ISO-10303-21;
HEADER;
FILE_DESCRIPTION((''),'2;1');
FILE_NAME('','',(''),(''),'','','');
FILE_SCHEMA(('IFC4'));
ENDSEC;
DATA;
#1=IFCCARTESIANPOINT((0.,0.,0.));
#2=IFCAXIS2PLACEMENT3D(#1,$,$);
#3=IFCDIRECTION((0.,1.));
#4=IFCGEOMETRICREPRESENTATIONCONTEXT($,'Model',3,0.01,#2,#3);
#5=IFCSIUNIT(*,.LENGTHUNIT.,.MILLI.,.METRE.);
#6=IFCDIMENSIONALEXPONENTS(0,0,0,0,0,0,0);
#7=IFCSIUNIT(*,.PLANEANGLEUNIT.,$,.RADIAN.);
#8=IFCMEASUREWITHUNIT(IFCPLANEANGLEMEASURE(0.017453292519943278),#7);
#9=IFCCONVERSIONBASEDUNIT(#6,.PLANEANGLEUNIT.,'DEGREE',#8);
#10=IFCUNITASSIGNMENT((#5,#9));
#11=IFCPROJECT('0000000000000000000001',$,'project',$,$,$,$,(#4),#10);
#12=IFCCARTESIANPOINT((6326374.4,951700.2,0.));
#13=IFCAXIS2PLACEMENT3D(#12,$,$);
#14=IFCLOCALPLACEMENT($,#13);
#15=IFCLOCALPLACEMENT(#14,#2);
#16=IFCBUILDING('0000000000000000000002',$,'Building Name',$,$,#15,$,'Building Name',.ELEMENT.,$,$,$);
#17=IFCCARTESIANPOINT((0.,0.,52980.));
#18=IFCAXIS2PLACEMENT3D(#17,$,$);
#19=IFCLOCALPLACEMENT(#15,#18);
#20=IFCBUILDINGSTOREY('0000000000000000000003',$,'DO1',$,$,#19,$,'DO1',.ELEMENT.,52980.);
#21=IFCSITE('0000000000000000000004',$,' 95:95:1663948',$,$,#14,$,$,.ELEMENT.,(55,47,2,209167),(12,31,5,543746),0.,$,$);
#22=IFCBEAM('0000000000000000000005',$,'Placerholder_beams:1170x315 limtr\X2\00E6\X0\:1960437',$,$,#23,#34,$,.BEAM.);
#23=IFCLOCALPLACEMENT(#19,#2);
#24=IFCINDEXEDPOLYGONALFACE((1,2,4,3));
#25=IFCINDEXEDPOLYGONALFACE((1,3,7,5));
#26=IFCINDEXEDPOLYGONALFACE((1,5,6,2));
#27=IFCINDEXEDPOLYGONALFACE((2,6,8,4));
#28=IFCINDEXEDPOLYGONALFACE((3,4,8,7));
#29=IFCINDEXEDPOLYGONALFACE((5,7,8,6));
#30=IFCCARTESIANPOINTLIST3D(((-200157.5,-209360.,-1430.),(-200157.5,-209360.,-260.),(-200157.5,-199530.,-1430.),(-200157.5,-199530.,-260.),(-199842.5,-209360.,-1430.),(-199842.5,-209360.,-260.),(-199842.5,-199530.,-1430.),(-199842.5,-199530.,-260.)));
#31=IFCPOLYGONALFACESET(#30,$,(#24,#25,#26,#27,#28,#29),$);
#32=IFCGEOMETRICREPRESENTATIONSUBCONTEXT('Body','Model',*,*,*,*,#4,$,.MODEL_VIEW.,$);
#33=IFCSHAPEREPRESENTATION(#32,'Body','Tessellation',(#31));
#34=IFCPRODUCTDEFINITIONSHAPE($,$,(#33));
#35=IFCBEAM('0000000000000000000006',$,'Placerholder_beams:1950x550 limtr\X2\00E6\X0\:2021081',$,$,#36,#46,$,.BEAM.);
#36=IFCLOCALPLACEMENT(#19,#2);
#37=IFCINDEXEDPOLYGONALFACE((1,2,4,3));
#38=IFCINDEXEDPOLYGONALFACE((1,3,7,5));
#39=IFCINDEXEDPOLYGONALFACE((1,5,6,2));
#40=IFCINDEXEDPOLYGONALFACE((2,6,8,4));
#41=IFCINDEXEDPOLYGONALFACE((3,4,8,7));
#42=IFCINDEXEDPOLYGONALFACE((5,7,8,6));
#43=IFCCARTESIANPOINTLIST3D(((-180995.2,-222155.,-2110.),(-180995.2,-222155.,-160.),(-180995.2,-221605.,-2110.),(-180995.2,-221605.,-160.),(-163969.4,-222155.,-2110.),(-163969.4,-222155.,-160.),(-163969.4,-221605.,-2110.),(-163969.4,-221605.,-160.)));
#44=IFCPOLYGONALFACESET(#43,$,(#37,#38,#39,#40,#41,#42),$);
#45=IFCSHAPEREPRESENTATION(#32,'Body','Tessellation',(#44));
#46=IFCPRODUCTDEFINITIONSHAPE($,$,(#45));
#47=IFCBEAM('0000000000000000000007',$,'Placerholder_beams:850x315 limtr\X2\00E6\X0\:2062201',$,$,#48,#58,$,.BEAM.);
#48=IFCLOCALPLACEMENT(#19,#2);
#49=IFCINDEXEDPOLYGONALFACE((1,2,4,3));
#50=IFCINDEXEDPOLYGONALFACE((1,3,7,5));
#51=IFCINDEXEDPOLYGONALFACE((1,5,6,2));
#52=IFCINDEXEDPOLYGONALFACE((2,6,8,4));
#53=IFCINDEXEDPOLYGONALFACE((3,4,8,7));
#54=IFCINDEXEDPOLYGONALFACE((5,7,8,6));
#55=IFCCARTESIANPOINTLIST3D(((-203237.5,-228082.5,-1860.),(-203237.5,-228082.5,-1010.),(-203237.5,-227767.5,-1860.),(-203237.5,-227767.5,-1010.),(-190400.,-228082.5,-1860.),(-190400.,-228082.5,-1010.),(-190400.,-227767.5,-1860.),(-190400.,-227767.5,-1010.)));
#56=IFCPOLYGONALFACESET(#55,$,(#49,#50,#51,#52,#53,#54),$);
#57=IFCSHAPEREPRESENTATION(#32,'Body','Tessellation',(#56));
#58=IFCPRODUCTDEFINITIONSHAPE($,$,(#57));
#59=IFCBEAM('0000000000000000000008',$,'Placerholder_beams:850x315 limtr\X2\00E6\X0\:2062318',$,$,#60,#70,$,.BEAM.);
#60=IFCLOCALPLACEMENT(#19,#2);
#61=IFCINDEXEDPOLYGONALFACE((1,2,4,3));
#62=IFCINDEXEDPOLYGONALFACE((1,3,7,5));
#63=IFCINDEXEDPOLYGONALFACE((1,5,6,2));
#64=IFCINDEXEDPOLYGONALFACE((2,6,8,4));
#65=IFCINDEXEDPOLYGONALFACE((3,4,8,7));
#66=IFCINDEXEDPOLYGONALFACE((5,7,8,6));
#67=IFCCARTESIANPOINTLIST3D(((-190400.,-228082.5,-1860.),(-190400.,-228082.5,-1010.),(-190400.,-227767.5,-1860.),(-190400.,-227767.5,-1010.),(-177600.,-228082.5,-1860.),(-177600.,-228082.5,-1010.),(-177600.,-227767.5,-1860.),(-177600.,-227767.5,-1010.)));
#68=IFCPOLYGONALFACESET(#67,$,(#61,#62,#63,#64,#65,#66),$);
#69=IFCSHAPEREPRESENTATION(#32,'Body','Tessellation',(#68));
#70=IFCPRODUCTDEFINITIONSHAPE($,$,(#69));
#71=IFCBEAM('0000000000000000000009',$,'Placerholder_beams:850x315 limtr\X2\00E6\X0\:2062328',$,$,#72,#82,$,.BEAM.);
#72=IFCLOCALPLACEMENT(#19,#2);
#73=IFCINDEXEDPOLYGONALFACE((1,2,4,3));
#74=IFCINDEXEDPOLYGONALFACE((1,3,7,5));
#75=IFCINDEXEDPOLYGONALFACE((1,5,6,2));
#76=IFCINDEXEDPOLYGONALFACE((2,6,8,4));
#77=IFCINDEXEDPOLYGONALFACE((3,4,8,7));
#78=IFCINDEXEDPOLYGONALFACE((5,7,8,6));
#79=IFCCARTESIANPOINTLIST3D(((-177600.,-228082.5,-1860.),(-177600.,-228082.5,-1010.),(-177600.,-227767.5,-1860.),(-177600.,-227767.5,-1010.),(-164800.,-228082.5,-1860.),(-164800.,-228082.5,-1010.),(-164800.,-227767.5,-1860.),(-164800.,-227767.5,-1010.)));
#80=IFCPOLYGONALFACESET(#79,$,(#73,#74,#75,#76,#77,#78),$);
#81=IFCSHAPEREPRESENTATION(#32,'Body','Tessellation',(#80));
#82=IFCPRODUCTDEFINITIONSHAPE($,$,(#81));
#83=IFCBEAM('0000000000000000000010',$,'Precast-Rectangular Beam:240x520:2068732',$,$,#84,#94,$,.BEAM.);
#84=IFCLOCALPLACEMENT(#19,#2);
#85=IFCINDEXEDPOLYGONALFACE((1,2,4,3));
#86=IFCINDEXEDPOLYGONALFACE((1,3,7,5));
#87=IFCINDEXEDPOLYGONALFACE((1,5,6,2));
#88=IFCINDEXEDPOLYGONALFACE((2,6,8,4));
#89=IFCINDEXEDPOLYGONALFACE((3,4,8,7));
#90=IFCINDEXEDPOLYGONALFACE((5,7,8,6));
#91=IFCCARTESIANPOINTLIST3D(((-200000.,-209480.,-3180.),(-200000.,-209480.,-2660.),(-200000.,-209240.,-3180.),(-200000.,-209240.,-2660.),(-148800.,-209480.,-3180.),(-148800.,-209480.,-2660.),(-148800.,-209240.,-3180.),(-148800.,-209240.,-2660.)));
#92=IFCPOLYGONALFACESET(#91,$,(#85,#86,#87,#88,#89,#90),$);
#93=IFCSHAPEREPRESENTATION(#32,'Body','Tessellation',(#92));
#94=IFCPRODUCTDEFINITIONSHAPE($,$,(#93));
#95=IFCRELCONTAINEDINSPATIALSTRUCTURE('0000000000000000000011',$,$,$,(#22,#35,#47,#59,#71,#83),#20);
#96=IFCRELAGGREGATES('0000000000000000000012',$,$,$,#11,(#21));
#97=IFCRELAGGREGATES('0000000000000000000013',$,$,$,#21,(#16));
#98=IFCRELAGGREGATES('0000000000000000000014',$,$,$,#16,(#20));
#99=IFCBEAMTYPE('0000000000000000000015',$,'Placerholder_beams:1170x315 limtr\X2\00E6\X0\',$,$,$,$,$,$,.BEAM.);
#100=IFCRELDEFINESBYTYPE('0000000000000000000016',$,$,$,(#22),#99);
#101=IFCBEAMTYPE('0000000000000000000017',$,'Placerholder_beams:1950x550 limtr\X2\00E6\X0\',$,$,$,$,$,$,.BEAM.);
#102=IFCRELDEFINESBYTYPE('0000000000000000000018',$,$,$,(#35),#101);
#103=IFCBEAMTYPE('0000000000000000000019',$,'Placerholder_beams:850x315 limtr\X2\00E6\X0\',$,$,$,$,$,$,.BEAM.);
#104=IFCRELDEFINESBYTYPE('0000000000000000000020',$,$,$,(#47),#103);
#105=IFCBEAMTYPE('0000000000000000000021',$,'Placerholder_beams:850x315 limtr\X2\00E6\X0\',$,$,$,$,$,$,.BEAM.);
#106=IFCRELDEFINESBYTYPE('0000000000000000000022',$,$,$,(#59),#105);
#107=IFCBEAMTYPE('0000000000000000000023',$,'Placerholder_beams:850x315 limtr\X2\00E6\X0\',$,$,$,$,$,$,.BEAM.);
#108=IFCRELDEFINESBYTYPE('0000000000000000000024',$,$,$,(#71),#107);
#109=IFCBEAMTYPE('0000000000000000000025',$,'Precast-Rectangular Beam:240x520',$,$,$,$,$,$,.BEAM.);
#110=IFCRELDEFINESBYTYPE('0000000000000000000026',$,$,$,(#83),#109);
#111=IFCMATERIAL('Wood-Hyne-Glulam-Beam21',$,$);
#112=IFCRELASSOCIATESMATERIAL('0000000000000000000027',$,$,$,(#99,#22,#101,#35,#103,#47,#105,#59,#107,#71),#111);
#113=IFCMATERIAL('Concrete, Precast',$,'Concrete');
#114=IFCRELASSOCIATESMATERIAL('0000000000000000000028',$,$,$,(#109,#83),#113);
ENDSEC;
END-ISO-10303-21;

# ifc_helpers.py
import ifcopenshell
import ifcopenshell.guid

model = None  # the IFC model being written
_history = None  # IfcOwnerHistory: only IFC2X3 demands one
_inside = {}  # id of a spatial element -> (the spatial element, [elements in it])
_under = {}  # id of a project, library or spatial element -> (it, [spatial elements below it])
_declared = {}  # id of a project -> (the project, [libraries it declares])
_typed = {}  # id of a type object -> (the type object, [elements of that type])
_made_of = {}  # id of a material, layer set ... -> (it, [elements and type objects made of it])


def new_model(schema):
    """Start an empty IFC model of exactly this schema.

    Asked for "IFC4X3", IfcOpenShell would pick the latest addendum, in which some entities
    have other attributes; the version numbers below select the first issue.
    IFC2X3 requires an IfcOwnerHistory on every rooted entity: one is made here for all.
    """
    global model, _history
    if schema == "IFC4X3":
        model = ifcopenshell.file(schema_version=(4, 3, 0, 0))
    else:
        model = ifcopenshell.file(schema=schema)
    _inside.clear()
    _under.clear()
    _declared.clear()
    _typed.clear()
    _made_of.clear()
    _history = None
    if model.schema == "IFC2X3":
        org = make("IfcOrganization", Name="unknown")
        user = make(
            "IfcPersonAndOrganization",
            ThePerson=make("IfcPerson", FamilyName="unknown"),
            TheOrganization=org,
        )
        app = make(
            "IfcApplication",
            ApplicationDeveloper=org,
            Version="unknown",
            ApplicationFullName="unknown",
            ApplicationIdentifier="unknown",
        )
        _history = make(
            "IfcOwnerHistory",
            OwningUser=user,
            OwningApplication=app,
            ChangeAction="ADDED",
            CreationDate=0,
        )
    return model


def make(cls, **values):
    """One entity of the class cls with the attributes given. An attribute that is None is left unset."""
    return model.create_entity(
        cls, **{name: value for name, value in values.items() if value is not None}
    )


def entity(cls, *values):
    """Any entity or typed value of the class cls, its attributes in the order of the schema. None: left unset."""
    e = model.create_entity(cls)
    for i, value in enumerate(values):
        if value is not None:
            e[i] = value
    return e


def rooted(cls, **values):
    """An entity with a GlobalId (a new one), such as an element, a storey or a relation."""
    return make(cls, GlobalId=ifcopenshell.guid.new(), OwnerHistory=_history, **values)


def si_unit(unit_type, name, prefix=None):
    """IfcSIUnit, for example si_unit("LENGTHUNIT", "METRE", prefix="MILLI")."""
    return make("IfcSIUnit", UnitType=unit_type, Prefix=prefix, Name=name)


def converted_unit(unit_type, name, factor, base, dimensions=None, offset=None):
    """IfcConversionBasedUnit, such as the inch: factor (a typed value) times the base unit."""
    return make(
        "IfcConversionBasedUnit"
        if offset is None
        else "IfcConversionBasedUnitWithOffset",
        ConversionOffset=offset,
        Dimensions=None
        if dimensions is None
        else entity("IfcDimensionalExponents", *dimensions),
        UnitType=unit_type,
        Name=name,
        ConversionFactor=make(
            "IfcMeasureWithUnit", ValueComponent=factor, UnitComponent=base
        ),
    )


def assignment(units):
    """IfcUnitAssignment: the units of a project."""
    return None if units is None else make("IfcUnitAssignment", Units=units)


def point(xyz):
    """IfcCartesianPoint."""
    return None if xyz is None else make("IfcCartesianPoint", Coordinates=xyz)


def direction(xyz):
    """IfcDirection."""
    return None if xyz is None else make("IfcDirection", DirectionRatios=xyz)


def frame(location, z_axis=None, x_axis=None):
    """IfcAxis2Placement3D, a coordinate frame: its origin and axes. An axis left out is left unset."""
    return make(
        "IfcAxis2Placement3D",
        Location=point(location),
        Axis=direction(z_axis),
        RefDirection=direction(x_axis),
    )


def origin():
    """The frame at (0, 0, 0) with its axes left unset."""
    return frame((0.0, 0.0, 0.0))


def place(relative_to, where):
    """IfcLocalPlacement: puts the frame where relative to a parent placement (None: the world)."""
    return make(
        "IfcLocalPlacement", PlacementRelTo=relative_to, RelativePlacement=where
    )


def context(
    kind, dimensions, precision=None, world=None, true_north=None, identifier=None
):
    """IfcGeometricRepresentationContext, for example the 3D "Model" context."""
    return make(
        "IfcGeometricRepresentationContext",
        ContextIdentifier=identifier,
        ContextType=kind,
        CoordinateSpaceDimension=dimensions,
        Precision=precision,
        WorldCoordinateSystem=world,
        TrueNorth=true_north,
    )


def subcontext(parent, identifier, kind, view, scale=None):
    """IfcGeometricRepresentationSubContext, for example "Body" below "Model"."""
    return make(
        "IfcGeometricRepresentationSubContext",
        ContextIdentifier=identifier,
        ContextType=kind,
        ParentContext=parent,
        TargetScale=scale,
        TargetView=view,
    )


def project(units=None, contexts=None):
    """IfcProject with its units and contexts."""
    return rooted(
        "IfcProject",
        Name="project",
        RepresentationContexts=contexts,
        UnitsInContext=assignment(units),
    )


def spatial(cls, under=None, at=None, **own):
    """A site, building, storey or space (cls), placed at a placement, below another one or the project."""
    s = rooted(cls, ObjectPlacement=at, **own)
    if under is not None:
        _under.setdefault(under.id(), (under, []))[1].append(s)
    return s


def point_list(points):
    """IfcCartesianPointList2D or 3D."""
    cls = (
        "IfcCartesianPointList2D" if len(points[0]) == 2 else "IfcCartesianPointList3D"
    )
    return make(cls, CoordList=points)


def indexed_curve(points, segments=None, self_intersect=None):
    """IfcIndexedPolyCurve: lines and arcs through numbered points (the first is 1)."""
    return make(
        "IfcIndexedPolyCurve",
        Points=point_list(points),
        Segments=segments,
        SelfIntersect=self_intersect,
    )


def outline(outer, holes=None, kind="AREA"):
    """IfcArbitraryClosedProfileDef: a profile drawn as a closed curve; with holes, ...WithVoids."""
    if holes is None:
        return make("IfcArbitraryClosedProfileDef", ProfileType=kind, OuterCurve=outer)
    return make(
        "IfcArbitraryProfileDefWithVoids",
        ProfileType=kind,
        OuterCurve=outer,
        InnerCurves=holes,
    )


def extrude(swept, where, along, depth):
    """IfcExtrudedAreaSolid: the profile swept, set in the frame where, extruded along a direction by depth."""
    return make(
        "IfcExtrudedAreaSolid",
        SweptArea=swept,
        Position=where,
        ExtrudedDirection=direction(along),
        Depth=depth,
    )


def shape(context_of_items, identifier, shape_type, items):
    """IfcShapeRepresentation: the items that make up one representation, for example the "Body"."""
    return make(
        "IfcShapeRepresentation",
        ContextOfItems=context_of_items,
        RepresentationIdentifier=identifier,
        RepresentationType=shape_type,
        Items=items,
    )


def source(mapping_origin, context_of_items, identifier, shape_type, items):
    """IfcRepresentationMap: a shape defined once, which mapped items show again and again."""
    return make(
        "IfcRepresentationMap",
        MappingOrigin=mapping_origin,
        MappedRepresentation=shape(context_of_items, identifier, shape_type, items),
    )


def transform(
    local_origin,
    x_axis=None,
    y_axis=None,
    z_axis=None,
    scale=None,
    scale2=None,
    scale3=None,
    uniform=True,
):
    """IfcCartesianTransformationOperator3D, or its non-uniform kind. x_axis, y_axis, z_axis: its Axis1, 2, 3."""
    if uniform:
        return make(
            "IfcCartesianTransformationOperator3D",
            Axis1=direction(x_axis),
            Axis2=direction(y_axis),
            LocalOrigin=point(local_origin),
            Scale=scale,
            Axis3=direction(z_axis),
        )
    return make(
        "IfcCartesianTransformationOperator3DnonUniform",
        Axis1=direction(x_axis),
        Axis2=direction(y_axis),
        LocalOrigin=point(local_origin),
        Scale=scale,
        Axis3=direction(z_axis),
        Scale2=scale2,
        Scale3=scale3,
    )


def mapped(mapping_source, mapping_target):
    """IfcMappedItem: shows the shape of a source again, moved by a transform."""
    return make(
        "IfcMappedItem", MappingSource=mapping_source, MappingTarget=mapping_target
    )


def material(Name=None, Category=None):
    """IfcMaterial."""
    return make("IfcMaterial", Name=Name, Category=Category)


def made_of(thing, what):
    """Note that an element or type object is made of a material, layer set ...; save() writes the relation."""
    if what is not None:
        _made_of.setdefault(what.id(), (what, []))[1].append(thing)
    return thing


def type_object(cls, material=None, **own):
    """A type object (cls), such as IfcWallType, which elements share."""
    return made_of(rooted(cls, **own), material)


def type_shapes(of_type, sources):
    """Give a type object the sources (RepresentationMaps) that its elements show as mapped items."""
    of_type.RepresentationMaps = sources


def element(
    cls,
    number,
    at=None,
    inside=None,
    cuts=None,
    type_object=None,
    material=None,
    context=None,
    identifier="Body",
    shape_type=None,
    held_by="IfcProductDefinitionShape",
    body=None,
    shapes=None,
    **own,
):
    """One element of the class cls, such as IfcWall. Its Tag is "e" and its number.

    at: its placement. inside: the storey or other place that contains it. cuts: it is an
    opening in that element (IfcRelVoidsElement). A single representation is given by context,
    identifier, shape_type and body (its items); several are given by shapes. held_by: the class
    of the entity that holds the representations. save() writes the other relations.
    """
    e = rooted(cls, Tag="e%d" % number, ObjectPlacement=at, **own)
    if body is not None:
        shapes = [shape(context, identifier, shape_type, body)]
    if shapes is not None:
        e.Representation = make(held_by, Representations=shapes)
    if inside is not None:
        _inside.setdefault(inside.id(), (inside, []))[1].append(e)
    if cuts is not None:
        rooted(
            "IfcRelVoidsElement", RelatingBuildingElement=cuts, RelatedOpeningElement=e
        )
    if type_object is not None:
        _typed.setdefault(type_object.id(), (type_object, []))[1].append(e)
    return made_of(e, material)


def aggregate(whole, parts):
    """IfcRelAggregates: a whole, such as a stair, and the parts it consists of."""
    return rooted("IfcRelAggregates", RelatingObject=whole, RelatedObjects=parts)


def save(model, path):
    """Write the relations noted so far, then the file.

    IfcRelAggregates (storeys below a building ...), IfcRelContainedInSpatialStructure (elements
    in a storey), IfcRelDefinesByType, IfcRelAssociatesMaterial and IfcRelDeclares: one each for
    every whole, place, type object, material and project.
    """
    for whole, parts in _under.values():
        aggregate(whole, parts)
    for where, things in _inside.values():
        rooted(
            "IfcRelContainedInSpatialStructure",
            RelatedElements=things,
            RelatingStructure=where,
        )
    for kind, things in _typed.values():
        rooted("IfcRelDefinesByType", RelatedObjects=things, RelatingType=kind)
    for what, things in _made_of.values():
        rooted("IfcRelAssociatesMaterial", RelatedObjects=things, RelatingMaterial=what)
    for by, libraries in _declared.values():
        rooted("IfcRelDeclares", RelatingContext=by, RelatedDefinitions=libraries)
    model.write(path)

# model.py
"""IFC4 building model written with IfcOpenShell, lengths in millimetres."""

from ifc_helpers import new_model, entity, si_unit, converted_unit, direction, frame, origin, place, context, subcontext, project, spatial, indexed_curve, outline, extrude, source, transform, mapped, material, type_object, type_shapes, element, save


model = new_model("IFC4")

# Units and contexts
model_context = context("Model", 3, precision=0.01, world=origin(), true_north=direction((0.0, 1.0)))
body_context = subcontext(model_context, "Body", "Model", "MODEL_VIEW")
ifc_project = project(units=[si_unit("LENGTHUNIT", "METRE", prefix="MILLI"), converted_unit("PLANEANGLEUNIT", "DEGREE", entity("IfcPlaneAngleMeasure", 0.017453292519943278), si_unit("PLANEANGLEUNIT", "RADIAN"), dimensions=[0, 0, 0, 0, 0, 0, 0])], contexts=[model_context])

# Site, building, storey
site_placement = place(None, frame((6326374.4, 951700.2, 0.0)))
site = spatial("IfcSite", under=ifc_project, at=site_placement, Name=" 95:95:1663948", CompositionType="ELEMENT", RefLatitude=(55, 47, 2, 209167), RefLongitude=(12, 31, 5, 543746), RefElevation=0.0)
building_placement = place(site_placement, origin())
building = spatial("IfcBuilding", under=site, at=building_placement, Name="Building Name", LongName="Building Name", CompositionType="ELEMENT")
storey_placement = place(building_placement, frame((0.0, 0.0, 52980.0)))
storey = spatial("IfcBuildingStorey", under=building, at=storey_placement, Name="DO1", LongName="DO1", CompositionType="ELEMENT", Elevation=52980.0)

# Beams
ifc_material_1 = material(Name="Wood-Hyne-Glulam-Beam21")
beam_type_1 = type_object("IfcBeamType", Name="Placerholder_beams:1170x315 limtræ", PredefinedType="BEAM", material=ifc_material_1)
shared_shape_1 = source(origin(), body_context, "Body", "SweptSolid", [
    extrude(outline(indexed_curve([(-4915.0, -157.5), (4915.0, -157.5), (4915.0, 157.5), (-4915.0, 157.5), (-4915.0, -157.5)], self_intersect=False)), frame((25.0, 0.0, -585.0)), (0.0, 0.0, 1.0), 1170.0),
])
type_shapes(beam_type_1, [shared_shape_1])
beam_1_placement = place(storey_placement, frame((-200000.0, -204420.0, -845.0), z_axis=(0.0, 0.0, 1.0), x_axis=(0.0, -1.0, 0.0)))
element("IfcBeam", 1, at=beam_1_placement, inside=storey, type_object=beam_type_1, material=ifc_material_1, Name="Placerholder_beams:1170x315 limtræ:1960437", PredefinedType="BEAM", context=body_context, shape_type="MappedRepresentation", body=[
    mapped(shared_shape_1, transform((0.0, 0.0, 0.0), scale=1.0)),
])
beam_type_2 = type_object("IfcBeamType", Name="Placerholder_beams:1950x550 limtræ", PredefinedType="BEAM", material=ifc_material_1)
shared_shape_2 = source(origin(), body_context, "Body", "SweptSolid", [
    extrude(outline(indexed_curve([(-8512.9, -275.0), (8512.9, -275.0), (8512.9, 275.0), (-8512.9, 275.0), (-8512.9, -275.0)], self_intersect=False)), frame((2091.6, 0.0, -975.0)), (0.0, 0.0, 1.0), 1950.0),
])
type_shapes(beam_type_2, [shared_shape_2])
beam_2_placement = place(storey_placement, frame((-174573.8, -221880.0, -1135.0)))
element("IfcBeam", 2, at=beam_2_placement, inside=storey, type_object=beam_type_2, material=ifc_material_1, Name="Placerholder_beams:1950x550 limtræ:2021081", PredefinedType="BEAM", context=body_context, shape_type="MappedRepresentation", body=[
    mapped(shared_shape_2, transform((0.0, 0.0, 0.0), scale=1.0)),
])
beam_type_3 = type_object("IfcBeamType", Name="Placerholder_beams:850x315 limtræ", PredefinedType="BEAM", material=ifc_material_1)
shared_shape_3 = source(origin(), body_context, "Body", "SweptSolid", [
    extrude(outline(indexed_curve([(-6418.8, -157.5), (6418.8, -157.5), (6418.8, 157.5), (-6418.8, 157.5), (-6418.8, -157.5)], self_intersect=False)), frame((99.0, 0.0, -425.0)), (0.0, 0.0, 1.0), 850.0),
])
type_shapes(beam_type_3, [shared_shape_3])
beam_3_placement = place(storey_placement, frame((-196917.7, -227925.0, -1435.0)))
element("IfcBeam", 3, at=beam_3_placement, inside=storey, type_object=beam_type_3, material=ifc_material_1, Name="Placerholder_beams:850x315 limtræ:2062201", PredefinedType="BEAM", context=body_context, shape_type="MappedRepresentation", body=[
    mapped(shared_shape_3, transform((0.0, 0.0, 0.0), scale=1.0)),
])
beam_type_4 = type_object("IfcBeamType", Name="Placerholder_beams:850x315 limtræ", PredefinedType="BEAM", material=ifc_material_1)
shared_shape_4 = source(origin(), body_context, "Body", "SweptSolid", [
    extrude(outline(indexed_curve([(-6400.0, -157.5), (6400.0, -157.5), (6400.0, 157.5), (-6400.0, 157.5), (-6400.0, -157.5)], self_intersect=False)), frame((-18.5, 0.0, -425.0)), (0.0, 0.0, 1.0), 850.0),
])
type_shapes(beam_type_4, [shared_shape_4])
beam_4_placement = place(storey_placement, frame((-183981.5, -227925.0, -1435.0)))
element("IfcBeam", 4, at=beam_4_placement, inside=storey, type_object=beam_type_4, material=ifc_material_1, Name="Placerholder_beams:850x315 limtræ:2062318", PredefinedType="BEAM", context=body_context, shape_type="MappedRepresentation", body=[
    mapped(shared_shape_4, transform((0.0, 0.0, 0.0), scale=1.0)),
])
beam_type_5 = type_object("IfcBeamType", Name="Placerholder_beams:850x315 limtræ", PredefinedType="BEAM", material=ifc_material_1)
shared_shape_5 = source(origin(), body_context, "Body", "SweptSolid", [
    extrude(outline(indexed_curve([(-6400.0, -157.5), (6400.0, -157.5), (6400.0, 157.5), (-6400.0, 157.5), (-6400.0, -157.5)], self_intersect=False)), frame((-18.4, 0.0, -425.0)), (0.0, 0.0, 1.0), 850.0),
])
type_shapes(beam_type_5, [shared_shape_5])
beam_5_placement = place(storey_placement, frame((-171181.6, -227925.0, -1435.0)))
element("IfcBeam", 5, at=beam_5_placement, inside=storey, type_object=beam_type_5, material=ifc_material_1, Name="Placerholder_beams:850x315 limtræ:2062328", PredefinedType="BEAM", context=body_context, shape_type="MappedRepresentation", body=[
    mapped(shared_shape_5, transform((0.0, 0.0, 0.0), scale=1.0)),
])
ifc_material_2 = material(Name="Concrete, Precast", Category="Concrete")
beam_type_6 = type_object("IfcBeamType", Name="Precast-Rectangular Beam:240x520", PredefinedType="BEAM", material=ifc_material_2)
shared_shape_6 = source(origin(), body_context, "Body", "SweptSolid", [
    extrude(outline(indexed_curve([(-25600.0, -120.0), (25600.0, -120.0), (25600.0, 120.0), (-25600.0, 120.0), (-25600.0, -120.0)], self_intersect=False)), frame((57.6, 0.0, -260.0), z_axis=(0.0, 0.0, 1.0), x_axis=(-1.0, 0.0, 0.0)), (0.0, 0.0, 1.0), 520.0),
])
type_shapes(beam_type_6, [shared_shape_6])
beam_6_placement = place(storey_placement, frame((-174457.6, -209360.0, -2920.0)))
element("IfcBeam", 6, at=beam_6_placement, inside=storey, type_object=beam_type_6, material=ifc_material_2, Name="Precast-Rectangular Beam:240x520:2068732", PredefinedType="BEAM", context=body_context, shape_type="MappedRepresentation", body=[
    mapped(shared_shape_6, transform((0.0, 0.0, 0.0), scale=1.0)),
])

save(model, "model.ifc")
